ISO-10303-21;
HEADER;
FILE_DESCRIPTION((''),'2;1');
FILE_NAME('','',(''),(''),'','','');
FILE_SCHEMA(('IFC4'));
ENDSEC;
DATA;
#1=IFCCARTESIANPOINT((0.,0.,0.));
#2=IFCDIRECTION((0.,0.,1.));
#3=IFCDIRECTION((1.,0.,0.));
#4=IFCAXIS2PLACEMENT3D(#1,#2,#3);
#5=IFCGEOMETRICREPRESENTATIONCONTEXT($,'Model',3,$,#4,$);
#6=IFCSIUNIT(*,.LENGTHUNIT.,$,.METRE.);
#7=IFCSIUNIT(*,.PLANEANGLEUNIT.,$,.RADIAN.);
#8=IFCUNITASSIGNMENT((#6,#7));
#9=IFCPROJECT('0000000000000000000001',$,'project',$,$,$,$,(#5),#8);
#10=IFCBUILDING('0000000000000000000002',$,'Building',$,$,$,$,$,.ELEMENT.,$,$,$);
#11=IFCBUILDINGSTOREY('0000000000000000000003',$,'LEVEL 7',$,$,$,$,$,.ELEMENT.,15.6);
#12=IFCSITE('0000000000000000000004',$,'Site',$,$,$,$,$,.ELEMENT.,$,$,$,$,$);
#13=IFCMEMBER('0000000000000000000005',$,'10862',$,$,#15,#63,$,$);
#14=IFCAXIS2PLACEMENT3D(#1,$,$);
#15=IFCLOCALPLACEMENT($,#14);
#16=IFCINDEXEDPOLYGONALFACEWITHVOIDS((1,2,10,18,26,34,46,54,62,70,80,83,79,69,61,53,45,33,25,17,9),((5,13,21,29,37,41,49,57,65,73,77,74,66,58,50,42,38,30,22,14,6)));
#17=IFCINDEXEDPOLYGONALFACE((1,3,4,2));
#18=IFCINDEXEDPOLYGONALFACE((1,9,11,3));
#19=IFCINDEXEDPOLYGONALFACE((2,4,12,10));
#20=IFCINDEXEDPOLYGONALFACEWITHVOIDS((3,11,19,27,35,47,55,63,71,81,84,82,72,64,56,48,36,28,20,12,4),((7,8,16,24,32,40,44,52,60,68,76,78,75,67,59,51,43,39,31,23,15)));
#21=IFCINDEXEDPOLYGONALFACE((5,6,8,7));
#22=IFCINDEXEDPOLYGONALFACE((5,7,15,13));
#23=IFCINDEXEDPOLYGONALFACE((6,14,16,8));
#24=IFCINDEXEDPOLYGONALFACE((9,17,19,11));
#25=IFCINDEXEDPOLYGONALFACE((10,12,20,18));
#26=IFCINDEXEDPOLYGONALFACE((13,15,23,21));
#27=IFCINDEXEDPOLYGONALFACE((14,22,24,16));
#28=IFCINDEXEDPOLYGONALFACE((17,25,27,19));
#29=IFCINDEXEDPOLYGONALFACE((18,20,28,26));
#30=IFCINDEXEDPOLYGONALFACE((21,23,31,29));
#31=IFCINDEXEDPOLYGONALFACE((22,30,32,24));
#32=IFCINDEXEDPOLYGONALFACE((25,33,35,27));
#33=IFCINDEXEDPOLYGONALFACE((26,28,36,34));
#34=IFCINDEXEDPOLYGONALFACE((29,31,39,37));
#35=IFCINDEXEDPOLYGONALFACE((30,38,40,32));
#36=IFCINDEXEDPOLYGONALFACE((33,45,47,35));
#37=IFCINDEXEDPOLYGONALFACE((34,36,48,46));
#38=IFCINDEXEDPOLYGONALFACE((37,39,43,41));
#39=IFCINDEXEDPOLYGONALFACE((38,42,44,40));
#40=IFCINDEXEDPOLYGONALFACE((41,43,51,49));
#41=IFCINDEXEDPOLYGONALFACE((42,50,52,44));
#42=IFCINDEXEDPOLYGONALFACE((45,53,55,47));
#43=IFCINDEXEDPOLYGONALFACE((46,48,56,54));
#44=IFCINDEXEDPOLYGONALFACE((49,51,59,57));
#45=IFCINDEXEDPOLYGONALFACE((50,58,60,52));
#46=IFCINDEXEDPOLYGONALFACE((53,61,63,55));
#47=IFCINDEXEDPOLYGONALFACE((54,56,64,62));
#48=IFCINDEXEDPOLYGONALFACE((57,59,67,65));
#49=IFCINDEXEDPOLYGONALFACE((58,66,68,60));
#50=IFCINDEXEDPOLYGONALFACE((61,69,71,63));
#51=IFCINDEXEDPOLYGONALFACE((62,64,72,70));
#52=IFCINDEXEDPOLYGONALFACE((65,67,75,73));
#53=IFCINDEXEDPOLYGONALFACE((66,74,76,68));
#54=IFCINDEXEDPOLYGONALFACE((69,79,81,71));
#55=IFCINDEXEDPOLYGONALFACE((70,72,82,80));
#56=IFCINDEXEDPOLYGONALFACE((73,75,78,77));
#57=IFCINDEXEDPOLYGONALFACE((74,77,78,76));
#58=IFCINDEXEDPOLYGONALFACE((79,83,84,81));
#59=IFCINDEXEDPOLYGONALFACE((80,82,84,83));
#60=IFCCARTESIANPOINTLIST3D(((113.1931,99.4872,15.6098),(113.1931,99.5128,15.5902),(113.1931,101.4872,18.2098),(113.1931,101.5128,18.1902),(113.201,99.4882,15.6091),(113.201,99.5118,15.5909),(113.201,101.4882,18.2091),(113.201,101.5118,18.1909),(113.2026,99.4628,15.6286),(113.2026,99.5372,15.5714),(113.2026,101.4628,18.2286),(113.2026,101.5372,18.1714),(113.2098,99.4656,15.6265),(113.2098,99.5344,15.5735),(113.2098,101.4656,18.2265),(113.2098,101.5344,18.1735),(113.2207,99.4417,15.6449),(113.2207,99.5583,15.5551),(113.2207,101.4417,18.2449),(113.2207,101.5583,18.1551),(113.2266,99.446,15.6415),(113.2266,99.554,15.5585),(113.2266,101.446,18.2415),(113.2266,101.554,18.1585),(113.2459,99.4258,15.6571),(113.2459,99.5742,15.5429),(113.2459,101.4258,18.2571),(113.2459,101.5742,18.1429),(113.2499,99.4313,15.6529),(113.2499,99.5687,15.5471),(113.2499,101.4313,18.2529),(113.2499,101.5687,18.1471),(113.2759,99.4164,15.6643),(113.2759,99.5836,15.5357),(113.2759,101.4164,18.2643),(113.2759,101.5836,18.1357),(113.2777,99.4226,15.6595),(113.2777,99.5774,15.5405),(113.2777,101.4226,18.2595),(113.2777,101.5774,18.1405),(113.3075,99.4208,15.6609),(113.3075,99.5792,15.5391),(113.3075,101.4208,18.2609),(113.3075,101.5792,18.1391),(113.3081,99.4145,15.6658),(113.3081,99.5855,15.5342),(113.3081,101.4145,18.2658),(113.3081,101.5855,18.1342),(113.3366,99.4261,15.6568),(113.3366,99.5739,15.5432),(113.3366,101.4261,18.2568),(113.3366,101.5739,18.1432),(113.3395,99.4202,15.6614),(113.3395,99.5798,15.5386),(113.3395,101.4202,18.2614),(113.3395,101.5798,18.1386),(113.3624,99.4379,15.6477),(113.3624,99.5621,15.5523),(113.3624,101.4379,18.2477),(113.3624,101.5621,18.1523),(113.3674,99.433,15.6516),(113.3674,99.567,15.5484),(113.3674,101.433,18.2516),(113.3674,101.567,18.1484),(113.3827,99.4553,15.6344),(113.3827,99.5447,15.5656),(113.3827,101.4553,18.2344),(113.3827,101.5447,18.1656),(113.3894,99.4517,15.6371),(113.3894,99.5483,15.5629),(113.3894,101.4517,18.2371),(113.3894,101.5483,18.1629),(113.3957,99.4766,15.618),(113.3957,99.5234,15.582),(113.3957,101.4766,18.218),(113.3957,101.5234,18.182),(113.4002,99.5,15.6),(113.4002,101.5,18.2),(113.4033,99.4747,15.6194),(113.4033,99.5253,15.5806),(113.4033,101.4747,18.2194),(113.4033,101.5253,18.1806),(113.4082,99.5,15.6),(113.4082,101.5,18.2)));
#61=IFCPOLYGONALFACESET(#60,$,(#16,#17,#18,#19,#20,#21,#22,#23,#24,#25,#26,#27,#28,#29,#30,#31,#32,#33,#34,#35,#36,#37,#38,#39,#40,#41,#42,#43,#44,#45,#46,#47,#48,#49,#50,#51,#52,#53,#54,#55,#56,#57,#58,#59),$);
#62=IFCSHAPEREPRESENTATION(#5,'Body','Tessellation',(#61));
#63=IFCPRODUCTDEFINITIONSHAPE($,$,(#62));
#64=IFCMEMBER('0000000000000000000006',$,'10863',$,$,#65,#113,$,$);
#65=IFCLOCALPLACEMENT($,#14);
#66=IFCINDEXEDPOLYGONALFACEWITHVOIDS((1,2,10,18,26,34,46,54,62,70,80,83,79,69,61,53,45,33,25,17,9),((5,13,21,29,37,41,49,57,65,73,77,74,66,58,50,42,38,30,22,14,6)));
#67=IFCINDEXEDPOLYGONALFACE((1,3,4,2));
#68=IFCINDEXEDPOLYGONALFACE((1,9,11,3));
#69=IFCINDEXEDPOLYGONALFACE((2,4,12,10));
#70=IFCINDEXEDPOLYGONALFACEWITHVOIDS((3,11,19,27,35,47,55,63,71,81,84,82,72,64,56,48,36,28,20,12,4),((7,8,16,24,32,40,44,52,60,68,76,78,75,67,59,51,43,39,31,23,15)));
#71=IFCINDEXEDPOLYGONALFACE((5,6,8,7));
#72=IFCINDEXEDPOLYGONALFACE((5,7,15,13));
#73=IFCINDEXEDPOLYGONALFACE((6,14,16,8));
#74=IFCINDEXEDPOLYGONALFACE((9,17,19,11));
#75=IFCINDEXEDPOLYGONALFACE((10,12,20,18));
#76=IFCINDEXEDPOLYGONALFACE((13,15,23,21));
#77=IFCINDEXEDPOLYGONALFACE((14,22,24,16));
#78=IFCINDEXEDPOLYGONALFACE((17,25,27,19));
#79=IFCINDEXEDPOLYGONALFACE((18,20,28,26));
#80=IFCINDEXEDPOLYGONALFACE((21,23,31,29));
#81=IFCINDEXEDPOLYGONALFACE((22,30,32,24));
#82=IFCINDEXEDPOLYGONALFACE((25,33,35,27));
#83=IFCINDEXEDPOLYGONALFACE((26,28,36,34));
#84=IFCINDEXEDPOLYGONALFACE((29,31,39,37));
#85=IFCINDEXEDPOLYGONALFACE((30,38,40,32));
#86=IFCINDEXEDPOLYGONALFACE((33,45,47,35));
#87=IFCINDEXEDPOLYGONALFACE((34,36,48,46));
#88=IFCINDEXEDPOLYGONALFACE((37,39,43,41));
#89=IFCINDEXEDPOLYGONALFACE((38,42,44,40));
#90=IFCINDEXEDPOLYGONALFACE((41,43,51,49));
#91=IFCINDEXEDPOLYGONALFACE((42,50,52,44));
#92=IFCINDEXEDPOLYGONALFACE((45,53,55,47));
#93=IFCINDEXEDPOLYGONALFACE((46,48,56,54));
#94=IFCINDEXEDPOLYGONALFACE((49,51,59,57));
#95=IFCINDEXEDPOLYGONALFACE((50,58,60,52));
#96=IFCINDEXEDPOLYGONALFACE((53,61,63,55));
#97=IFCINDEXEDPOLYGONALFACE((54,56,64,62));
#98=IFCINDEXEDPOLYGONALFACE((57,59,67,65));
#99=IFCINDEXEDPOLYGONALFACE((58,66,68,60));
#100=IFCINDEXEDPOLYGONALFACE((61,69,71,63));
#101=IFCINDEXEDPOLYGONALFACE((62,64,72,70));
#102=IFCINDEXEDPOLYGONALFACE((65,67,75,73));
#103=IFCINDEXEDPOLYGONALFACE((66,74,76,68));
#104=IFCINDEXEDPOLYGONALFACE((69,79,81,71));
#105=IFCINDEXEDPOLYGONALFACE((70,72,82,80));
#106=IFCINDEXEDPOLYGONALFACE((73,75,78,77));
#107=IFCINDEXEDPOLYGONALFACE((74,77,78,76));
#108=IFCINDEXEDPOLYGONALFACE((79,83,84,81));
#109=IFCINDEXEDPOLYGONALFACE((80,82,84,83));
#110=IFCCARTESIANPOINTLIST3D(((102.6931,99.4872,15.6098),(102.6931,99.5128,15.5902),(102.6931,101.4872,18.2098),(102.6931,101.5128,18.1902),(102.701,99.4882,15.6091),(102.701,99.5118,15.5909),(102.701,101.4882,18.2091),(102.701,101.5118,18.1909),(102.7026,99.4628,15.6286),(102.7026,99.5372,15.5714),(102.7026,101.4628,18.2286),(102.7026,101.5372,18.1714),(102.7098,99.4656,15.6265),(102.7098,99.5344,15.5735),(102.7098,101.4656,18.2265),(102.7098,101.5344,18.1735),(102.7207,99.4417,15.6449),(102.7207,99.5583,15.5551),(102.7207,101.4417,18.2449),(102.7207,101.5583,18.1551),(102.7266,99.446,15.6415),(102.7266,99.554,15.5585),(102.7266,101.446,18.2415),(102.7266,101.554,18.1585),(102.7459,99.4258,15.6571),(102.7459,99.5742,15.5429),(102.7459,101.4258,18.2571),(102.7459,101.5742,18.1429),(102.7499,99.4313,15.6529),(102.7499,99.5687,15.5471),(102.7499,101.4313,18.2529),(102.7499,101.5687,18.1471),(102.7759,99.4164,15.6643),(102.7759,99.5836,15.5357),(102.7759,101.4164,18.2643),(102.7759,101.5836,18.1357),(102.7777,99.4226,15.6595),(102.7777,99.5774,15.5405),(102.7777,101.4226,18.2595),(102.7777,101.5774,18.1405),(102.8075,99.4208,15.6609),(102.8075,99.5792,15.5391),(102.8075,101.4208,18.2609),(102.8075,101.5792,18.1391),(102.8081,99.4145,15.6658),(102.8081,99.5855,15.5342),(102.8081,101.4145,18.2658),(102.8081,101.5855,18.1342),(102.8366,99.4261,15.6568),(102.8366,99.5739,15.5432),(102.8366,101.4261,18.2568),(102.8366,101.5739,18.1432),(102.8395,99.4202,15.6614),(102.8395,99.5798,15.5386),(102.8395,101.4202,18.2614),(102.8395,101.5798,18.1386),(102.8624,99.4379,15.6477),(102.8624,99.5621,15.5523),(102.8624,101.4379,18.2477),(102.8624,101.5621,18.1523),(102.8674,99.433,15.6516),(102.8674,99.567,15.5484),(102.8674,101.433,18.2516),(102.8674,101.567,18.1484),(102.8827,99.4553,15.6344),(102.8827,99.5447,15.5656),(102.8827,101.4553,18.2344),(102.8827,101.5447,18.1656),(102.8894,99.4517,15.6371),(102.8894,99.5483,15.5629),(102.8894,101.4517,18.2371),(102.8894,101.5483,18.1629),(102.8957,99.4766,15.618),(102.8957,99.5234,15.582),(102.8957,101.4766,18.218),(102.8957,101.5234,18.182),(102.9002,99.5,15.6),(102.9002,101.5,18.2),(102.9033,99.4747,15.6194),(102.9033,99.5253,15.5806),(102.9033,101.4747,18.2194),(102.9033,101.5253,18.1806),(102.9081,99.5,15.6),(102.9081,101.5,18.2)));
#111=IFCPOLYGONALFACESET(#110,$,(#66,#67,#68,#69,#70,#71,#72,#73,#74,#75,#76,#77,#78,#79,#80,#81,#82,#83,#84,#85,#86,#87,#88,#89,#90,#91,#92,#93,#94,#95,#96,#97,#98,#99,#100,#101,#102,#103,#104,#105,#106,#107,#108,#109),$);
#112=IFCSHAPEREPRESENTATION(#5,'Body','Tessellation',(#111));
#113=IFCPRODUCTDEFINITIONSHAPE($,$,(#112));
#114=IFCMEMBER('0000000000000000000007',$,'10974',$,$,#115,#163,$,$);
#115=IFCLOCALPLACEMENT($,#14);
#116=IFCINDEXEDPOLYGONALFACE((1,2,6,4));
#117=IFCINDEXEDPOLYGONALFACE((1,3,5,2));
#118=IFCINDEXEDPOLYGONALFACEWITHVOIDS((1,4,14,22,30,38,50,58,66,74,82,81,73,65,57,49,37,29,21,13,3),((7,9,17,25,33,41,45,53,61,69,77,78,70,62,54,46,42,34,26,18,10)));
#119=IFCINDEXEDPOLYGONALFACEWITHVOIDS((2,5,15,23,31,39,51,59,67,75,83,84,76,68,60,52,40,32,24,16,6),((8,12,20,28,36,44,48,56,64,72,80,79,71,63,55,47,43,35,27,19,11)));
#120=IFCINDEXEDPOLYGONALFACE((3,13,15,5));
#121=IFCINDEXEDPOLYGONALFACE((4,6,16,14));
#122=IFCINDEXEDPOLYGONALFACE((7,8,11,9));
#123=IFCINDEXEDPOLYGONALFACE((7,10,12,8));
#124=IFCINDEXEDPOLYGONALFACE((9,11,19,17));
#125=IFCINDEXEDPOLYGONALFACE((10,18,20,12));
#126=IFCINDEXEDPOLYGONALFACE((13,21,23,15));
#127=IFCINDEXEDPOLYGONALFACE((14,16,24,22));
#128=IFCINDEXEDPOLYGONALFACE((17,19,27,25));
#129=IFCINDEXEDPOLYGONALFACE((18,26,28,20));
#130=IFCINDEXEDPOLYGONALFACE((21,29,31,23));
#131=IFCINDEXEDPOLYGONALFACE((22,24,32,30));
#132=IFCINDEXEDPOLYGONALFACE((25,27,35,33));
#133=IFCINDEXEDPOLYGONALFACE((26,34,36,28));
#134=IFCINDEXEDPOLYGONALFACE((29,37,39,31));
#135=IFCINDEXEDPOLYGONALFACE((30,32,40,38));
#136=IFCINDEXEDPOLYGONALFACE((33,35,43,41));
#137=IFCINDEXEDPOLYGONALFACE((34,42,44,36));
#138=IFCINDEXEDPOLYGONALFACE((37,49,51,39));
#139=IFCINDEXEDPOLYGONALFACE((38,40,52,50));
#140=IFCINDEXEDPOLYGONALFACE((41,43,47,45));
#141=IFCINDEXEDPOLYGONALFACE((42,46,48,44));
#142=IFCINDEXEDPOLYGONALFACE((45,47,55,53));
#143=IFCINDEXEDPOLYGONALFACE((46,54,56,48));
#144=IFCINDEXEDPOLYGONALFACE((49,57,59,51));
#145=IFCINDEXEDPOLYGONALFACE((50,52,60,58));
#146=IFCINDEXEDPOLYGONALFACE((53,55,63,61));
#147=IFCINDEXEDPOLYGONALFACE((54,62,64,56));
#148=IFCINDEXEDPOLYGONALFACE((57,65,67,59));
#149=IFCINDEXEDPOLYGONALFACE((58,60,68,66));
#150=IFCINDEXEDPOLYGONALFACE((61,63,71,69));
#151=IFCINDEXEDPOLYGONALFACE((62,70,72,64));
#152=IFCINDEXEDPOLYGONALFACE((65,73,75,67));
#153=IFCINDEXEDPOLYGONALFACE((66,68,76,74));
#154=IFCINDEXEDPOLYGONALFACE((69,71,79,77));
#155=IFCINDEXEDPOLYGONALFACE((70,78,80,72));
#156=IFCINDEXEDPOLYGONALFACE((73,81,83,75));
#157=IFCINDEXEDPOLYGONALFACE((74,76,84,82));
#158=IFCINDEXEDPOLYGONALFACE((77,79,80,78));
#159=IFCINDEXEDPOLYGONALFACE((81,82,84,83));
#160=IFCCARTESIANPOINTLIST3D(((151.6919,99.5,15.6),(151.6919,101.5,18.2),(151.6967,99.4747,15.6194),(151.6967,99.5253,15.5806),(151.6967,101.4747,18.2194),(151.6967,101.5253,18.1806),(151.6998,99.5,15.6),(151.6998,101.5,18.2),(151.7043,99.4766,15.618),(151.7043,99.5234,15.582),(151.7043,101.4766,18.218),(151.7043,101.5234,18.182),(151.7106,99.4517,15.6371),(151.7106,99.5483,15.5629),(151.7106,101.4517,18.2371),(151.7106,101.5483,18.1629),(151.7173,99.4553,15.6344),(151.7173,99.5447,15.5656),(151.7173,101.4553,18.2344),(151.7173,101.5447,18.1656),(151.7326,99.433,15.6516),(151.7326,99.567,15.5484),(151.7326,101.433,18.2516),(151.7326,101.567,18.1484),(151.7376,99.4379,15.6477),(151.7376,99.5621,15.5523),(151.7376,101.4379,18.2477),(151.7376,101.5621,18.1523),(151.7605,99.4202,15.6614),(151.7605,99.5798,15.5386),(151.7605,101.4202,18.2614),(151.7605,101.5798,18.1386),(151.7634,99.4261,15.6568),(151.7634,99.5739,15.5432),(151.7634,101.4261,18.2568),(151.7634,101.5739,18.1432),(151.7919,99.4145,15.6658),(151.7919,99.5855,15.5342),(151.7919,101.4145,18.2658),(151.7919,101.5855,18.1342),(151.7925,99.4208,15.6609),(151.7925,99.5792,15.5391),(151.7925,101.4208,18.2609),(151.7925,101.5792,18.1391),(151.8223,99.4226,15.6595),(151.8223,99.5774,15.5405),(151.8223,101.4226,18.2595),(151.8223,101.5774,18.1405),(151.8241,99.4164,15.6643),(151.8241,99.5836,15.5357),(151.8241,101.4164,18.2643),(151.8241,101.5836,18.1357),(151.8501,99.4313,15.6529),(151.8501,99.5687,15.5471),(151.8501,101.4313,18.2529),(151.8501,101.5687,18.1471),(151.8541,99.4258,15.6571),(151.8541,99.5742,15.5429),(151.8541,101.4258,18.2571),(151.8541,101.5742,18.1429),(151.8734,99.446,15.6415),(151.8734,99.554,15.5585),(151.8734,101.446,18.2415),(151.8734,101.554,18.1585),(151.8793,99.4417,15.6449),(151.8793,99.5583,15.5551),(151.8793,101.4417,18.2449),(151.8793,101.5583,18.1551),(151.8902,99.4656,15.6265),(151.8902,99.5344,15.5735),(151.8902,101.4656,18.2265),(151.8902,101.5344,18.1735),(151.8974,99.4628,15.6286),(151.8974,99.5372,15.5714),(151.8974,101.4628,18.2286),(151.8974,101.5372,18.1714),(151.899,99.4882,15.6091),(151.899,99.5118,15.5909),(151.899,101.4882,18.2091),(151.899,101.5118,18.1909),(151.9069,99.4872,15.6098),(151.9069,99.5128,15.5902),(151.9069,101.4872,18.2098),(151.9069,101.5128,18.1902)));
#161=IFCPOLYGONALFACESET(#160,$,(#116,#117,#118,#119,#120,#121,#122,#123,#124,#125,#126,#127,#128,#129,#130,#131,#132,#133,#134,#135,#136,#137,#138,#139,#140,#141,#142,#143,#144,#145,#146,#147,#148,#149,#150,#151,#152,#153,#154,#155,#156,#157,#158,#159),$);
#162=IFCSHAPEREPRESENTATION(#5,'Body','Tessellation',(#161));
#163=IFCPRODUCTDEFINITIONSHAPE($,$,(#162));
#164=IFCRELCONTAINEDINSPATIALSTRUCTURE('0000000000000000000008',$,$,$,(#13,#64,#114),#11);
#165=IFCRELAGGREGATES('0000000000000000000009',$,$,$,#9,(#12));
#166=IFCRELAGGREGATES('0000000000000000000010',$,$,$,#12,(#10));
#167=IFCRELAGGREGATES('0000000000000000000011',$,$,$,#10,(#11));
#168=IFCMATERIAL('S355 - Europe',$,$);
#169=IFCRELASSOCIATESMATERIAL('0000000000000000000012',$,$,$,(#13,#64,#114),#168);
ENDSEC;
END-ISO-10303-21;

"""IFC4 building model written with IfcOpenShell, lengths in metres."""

from ifc_helpers import new_model, si_unit, frame, origin_with_axes, origin_2d_with_axis, place, context, project, spatial, hollow_circle, extrude, material, material_profile, profile_set, profile_usage, element, save


model = new_model("IFC4")

# Units and contexts
model_context = context("Model", 3, world=origin_with_axes())
ifc_project = project(units=[si_unit("LENGTHUNIT", "METRE"), si_unit("PLANEANGLEUNIT", "RADIAN")], contexts=[model_context])

# Site, building, storey
site = spatial("IfcSite", under=ifc_project, Name="Site", CompositionType="ELEMENT")
building = spatial("IfcBuilding", under=site, Name="Building", CompositionType="ELEMENT")
storey = spatial("IfcBuildingStorey", under=building, Name="LEVEL 7", CompositionType="ELEMENT", Elevation=15.6)

# Shared definitions
ifc_material = material(Name="S355 - Europe")

# Members
ifc_material_profile_1 = material_profile(ifc_material, hollow_circle(Radius=0.1081, WallThickness=0.008, at=origin_2d_with_axis()))
ifc_profile_set_1 = profile_set([ifc_material_profile_1])
ifc_profile_usage_1 = profile_usage(ifc_profile_set_1, cardinal=10)
member_1_placement = place(None, frame((113.3, 101.5, 18.2), z_axis=(0.0, -0.609711, -0.792624), x_axis=(1.0, 0.0, 0.0)))
element("IfcMember", 1, at=member_1_placement, inside=storey, material=ifc_profile_usage_1, Name="10862", context=model_context, shape_type="SweptSolid", body=[
    extrude(hollow_circle(Radius=0.1081, WallThickness=0.008, at=origin_2d_with_axis()), origin_with_axes(), (0.0, 0.0, 1.0), 3.2802),
])
ifc_material_profile_2 = material_profile(ifc_material, hollow_circle(Radius=0.1081, WallThickness=0.008, at=origin_2d_with_axis()))
ifc_profile_set_2 = profile_set([ifc_material_profile_2])
ifc_profile_usage_2 = profile_usage(ifc_profile_set_2, cardinal=10)
member_2_placement = place(None, frame((102.8, 101.5, 18.2), z_axis=(0.0, -0.609711, -0.792624), x_axis=(1.0, 0.0, 0.0)))
element("IfcMember", 2, at=member_2_placement, inside=storey, material=ifc_profile_usage_2, Name="10863", context=model_context, shape_type="SweptSolid", body=[
    extrude(hollow_circle(Radius=0.1081, WallThickness=0.008, at=origin_2d_with_axis()), origin_with_axes(), (0.0, 0.0, 1.0), 3.2802),
])
ifc_material_profile_3 = material_profile(ifc_material, hollow_circle(Radius=0.1081, WallThickness=0.008, at=origin_2d_with_axis()))
ifc_profile_set_3 = profile_set([ifc_material_profile_3])
ifc_profile_usage_3 = profile_usage(ifc_profile_set_3, cardinal=10)
member_3_placement = place(None, frame((151.8, 99.5, 15.6), z_axis=(0.0, 0.609711, 0.792624), x_axis=(-1.0, 0.0, 0.0)))
element("IfcMember", 3, at=member_3_placement, inside=storey, material=ifc_profile_usage_3, Name="10974", context=model_context, shape_type="SweptSolid", body=[
    extrude(hollow_circle(Radius=0.1081, WallThickness=0.008, at=origin_2d_with_axis()), origin_with_axes(), (0.0, 0.0, 1.0), 3.2802),
])

save(model, "model.ifc")
